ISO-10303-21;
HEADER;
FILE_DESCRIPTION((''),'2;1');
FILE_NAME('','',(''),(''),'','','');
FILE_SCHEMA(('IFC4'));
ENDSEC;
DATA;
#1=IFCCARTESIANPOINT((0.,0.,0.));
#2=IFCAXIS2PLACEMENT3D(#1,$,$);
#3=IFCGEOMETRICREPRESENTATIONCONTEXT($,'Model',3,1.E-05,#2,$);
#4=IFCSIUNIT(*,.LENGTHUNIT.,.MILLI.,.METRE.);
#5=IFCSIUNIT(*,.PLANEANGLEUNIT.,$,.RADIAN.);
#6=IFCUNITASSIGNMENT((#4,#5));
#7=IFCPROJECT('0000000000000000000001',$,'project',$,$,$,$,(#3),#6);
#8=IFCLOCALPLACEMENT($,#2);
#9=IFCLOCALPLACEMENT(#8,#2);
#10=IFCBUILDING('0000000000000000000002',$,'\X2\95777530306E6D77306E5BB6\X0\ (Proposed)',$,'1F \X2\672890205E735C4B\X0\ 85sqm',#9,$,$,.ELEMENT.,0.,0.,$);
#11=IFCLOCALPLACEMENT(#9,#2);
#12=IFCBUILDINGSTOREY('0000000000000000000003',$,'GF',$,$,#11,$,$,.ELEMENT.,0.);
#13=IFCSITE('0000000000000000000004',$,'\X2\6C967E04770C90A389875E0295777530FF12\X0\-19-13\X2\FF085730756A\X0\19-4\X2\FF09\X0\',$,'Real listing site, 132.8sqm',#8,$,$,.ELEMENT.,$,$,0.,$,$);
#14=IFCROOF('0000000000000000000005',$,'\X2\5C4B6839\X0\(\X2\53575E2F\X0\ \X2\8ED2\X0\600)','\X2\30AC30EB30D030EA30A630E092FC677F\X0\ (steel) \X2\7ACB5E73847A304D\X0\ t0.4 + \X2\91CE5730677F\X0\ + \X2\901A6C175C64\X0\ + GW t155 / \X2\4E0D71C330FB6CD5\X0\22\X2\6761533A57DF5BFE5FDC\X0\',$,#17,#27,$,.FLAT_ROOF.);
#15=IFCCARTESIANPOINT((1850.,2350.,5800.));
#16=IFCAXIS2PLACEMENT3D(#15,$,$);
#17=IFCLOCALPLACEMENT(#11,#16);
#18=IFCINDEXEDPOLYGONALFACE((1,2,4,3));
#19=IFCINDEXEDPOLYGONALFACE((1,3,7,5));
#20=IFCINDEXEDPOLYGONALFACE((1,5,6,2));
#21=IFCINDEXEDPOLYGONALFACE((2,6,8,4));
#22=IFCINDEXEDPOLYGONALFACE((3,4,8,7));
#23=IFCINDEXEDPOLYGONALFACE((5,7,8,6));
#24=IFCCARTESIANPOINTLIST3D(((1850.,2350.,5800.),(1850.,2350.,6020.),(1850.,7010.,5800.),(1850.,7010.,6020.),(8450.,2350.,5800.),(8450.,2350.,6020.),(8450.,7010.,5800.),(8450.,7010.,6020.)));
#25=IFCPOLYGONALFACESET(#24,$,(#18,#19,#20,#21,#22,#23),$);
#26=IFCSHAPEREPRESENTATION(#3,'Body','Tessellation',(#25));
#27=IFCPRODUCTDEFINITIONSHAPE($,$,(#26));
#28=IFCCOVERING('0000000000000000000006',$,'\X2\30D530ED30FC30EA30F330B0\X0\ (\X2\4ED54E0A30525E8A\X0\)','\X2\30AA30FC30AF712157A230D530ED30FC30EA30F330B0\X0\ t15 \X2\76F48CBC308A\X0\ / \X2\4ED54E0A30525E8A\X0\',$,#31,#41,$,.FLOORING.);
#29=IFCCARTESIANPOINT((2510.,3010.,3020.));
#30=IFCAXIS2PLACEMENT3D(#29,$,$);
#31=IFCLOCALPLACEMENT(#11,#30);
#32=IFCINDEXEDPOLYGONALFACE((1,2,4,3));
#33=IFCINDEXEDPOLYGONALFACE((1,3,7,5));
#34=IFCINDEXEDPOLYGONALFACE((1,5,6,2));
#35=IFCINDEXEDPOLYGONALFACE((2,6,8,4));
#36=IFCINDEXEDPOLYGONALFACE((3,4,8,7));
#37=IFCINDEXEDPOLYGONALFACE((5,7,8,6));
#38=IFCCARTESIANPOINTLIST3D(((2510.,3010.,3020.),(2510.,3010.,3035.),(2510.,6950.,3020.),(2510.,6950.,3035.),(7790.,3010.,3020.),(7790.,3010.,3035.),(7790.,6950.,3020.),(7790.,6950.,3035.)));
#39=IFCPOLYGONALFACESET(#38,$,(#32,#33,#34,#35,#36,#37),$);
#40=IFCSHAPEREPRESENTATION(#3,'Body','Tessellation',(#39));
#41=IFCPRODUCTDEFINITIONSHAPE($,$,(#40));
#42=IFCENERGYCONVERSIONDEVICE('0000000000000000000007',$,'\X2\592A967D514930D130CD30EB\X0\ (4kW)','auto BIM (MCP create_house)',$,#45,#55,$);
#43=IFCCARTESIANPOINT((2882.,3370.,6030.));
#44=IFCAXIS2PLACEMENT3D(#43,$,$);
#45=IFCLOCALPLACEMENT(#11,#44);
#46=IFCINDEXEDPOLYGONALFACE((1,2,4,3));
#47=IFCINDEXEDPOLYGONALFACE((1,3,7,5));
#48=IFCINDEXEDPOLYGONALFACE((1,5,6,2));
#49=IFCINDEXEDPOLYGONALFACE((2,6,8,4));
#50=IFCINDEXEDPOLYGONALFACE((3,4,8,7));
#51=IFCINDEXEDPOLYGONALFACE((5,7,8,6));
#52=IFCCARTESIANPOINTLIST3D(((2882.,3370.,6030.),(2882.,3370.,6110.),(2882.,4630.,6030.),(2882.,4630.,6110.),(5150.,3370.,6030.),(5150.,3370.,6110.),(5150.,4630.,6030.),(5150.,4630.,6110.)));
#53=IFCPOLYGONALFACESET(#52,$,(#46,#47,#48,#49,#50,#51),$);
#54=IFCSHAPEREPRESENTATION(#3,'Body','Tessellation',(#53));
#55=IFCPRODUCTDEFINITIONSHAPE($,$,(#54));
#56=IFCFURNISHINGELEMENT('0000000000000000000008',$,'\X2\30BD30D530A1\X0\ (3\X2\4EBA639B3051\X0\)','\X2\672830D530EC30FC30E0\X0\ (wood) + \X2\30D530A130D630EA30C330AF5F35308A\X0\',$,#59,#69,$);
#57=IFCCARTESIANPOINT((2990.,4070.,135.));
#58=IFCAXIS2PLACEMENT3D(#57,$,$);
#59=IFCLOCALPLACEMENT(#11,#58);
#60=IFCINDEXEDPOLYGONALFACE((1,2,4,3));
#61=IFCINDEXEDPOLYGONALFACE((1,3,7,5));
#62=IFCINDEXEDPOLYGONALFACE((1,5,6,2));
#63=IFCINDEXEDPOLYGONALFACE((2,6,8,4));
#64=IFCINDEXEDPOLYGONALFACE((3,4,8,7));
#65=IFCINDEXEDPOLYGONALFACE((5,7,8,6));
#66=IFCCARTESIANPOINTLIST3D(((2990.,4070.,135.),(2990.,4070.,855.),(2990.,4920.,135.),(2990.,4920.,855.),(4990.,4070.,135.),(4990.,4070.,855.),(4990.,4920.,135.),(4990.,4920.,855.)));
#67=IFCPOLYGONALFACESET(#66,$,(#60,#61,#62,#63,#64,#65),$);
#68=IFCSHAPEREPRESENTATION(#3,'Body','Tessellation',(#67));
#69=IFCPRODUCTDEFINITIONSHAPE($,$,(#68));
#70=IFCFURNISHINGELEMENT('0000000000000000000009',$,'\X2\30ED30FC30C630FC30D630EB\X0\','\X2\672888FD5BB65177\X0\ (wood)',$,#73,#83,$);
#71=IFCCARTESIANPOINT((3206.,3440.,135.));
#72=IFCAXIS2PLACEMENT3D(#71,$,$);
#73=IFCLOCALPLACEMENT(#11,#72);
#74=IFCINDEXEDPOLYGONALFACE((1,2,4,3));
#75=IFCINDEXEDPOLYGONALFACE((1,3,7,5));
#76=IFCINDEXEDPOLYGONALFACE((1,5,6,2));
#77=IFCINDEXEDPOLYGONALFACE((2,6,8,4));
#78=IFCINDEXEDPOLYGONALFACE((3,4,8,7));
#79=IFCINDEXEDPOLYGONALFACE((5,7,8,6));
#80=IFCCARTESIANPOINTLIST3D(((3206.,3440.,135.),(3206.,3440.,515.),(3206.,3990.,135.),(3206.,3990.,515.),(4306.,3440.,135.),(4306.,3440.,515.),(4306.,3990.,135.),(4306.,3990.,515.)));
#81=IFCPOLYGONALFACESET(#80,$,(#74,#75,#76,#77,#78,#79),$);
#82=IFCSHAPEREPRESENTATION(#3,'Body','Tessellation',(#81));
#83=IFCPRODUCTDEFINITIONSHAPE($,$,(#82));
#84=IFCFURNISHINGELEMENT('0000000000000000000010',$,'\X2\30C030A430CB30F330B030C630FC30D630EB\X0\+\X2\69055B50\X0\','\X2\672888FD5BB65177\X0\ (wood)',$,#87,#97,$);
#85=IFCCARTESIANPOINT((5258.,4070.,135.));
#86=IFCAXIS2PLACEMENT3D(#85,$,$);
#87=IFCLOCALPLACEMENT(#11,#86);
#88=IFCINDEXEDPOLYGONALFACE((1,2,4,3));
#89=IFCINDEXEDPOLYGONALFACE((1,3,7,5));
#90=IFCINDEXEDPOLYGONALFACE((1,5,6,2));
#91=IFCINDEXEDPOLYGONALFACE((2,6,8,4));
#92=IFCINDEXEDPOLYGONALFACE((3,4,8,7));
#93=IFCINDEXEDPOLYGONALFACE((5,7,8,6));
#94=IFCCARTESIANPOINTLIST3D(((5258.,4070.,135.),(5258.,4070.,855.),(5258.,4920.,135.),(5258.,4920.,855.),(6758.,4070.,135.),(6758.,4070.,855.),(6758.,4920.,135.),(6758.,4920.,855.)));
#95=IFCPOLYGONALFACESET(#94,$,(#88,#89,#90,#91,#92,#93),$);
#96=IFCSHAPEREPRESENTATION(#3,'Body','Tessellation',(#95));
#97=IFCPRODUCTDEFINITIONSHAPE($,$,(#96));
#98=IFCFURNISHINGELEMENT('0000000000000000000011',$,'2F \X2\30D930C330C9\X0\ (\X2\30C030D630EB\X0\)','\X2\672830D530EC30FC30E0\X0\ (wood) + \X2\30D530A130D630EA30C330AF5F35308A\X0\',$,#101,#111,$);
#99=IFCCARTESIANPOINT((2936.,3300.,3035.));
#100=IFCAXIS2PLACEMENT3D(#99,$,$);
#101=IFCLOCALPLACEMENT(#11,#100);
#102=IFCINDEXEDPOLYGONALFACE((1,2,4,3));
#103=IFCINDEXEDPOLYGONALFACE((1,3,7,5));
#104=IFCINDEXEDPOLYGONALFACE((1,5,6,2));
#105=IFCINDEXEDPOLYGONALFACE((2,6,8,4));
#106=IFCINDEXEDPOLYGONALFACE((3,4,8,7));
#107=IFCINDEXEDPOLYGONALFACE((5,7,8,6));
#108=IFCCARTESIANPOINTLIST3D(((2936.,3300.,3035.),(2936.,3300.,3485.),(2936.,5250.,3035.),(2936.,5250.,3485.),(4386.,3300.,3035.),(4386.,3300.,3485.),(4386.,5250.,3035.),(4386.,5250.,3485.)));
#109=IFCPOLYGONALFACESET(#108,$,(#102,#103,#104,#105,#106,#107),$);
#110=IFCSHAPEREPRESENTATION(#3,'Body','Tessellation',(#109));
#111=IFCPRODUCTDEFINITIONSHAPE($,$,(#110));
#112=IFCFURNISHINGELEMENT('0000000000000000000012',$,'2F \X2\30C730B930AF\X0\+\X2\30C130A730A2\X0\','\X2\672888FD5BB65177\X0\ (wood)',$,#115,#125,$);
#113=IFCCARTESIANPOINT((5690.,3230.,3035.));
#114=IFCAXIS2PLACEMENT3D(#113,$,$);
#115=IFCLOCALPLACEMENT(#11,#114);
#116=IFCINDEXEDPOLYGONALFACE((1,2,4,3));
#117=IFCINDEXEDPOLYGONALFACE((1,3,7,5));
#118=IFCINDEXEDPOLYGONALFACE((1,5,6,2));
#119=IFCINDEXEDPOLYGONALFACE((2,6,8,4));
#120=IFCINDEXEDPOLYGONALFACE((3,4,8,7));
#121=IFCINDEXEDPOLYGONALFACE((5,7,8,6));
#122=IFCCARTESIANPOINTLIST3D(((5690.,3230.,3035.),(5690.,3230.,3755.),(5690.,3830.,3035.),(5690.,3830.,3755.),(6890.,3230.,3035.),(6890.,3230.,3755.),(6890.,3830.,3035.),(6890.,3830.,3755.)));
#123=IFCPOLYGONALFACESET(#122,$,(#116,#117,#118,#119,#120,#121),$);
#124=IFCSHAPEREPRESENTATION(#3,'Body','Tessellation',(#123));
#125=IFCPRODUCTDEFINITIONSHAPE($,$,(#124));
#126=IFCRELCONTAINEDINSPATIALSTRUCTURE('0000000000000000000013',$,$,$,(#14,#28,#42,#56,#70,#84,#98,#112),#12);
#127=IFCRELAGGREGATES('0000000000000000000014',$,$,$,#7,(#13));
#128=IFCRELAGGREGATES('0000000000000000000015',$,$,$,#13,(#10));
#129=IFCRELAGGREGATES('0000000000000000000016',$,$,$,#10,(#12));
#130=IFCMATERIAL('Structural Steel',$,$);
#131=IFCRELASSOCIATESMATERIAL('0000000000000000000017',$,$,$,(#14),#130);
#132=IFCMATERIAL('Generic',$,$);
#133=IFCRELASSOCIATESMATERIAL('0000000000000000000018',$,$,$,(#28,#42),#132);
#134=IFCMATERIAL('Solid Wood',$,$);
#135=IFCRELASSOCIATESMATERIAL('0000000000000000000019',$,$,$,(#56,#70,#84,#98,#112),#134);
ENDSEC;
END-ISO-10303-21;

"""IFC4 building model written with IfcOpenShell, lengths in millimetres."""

from ifc_helpers import new_model, si_unit, frame, frame_2d, origin, place, context, project, spatial, rectangle, extrude, material, element, save


model = new_model("IFC4")

# Units and contexts
model_context = context("Model", 3, precision=1e-05, world=origin())
ifc_project = project(units=[si_unit("LENGTHUNIT", "METRE", prefix="MILLI"), si_unit("PLANEANGLEUNIT", "RADIAN")], contexts=[model_context])

# Site, building, storey
site_placement = place(None, origin())
site = spatial("IfcSite", under=ifc_project, at=site_placement, Name="沖縄県那覇市長田２-19-13（地番19-4）", ObjectType="Real listing site, 132.8sqm", CompositionType="ELEMENT", RefElevation=0.0)
building_placement = place(site_placement, origin())
building = spatial("IfcBuilding", under=site, at=building_placement, Name="長田の海の家 (Proposed)", ObjectType="1F 木造平屋 85sqm", CompositionType="ELEMENT", ElevationOfRefHeight=0.0, ElevationOfTerrain=0.0)
storey_placement = place(building_placement, origin())
storey = spatial("IfcBuildingStorey", under=building, at=storey_placement, Name="GF", CompositionType="ELEMENT", Elevation=0.0)

# Shared definitions
ifc_material_1 = material(Name="Solid Wood")

# Shared definitions
ifc_material_2 = material(Name="Generic")

# Roof
ifc_material_3 = material(Name="Structural Steel")
for number, where, name in (
    (1, (1850.0, 2350.0, 5800.0), "屋根(南帯 軒600)"),
):
    element("IfcRoof", number, at=place(storey_placement, frame(where)), inside=storey, material=ifc_material_3, Name=name, Description="ガルバリウム鋼板 (steel) 立平葺き t0.4 + 野地板 + 通気層 + GW t155 / 不燃・法22条区域対応", PredefinedType="FLAT_ROOF", context=model_context, shape_type="SweptSolid", body=[
        extrude(rectangle(XDim=6600.0, YDim=4660.0, at=frame_2d((3300.0, 2330.0))), frame((1850.0, 2350.0, 5800.0)), (0.0, 0.0, 1.0), 220.0),
    ])

# Covering
covering_placement = place(storey_placement, frame((2510.0, 3010.0, 3020.0)))
element("IfcCovering", 2, at=covering_placement, inside=storey, material=ifc_material_2, Name="フローリング (仕上げ床)", Description="オーク無垢フローリング t15 直貼り / 仕上げ床", PredefinedType="FLOORING", context=model_context, shape_type="SweptSolid", body=[
    extrude(rectangle(XDim=5280.0, YDim=3940.0, at=frame_2d((2640.0, 1970.0))), frame((2510.0, 3010.0, 3020.0)), (0.0, 0.0, 1.0), 15.0),
])

# Energy conversion device
energy_conversion_device_placement = place(storey_placement, frame((2882.0, 3370.0, 6030.0)))
element("IfcEnergyConversionDevice", 3, at=energy_conversion_device_placement, inside=storey, material=ifc_material_2, Name="太陽光パネル (4kW)", Description="auto BIM (MCP create_house)", context=model_context, shape_type="SweptSolid", body=[
    extrude(rectangle(XDim=2268.0, YDim=1260.0, at=frame_2d((1134.0, 630.0))), frame((2882.0, 3370.0, 6030.0)), (0.0, 0.0, 1.0), 80.0),
])

# Furnishing elements
furnishing_1_placement = place(storey_placement, frame((2990.0, 4070.0, 135.0)))
element("IfcFurnishingElement", 4, at=furnishing_1_placement, inside=storey, material=ifc_material_1, Name="ソファ (3人掛け)", Description="木フレーム (wood) + ファブリック張り", context=model_context, shape_type="SweptSolid", body=[
    extrude(rectangle(XDim=2000.0, YDim=850.0, at=frame_2d((1000.0, 425.0))), frame((2990.0, 4070.0, 135.0)), (0.0, 0.0, 1.0), 720.0),
])
furnishing_2_placement = place(storey_placement, frame((3206.0, 3440.0, 135.0)))
element("IfcFurnishingElement", 5, at=furnishing_2_placement, inside=storey, material=ifc_material_1, Name="ローテーブル", Description="木製家具 (wood)", context=model_context, shape_type="SweptSolid", body=[
    extrude(rectangle(XDim=1100.0, YDim=550.0, at=frame_2d((550.0, 275.0))), frame((3206.0, 3440.0, 135.0)), (0.0, 0.0, 1.0), 380.0),
])
furnishing_3_placement = place(storey_placement, frame((5258.0, 4070.0, 135.0)))
element("IfcFurnishingElement", 6, at=furnishing_3_placement, inside=storey, material=ifc_material_1, Name="ダイニングテーブル+椅子", Description="木製家具 (wood)", context=model_context, shape_type="SweptSolid", body=[
    extrude(rectangle(XDim=1500.0, YDim=850.0, at=frame_2d((750.0, 425.0))), frame((5258.0, 4070.0, 135.0)), (0.0, 0.0, 1.0), 720.0),
])
furnishing_4_placement = place(storey_placement, frame((2936.0, 3300.0, 3035.0)))
element("IfcFurnishingElement", 7, at=furnishing_4_placement, inside=storey, material=ifc_material_1, Name="2F ベッド (ダブル)", Description="木フレーム (wood) + ファブリック張り", context=model_context, shape_type="SweptSolid", body=[
    extrude(rectangle(XDim=1450.0, YDim=1950.0, at=frame_2d((725.0, 975.0))), frame((2936.0, 3300.0, 3035.0)), (0.0, 0.0, 1.0), 450.0),
])
furnishing_5_placement = place(storey_placement, frame((5690.0, 3230.0, 3035.0)))
element("IfcFurnishingElement", 8, at=furnishing_5_placement, inside=storey, material=ifc_material_1, Name="2F デスク+チェア", Description="木製家具 (wood)", context=model_context, shape_type="SweptSolid", body=[
    extrude(rectangle(XDim=1200.0, YDim=600.0, at=frame_2d((600.0, 300.0))), frame((5690.0, 3230.0, 3035.0)), (0.0, 0.0, 1.0), 720.0),
])

save(model, "model.ifc")
